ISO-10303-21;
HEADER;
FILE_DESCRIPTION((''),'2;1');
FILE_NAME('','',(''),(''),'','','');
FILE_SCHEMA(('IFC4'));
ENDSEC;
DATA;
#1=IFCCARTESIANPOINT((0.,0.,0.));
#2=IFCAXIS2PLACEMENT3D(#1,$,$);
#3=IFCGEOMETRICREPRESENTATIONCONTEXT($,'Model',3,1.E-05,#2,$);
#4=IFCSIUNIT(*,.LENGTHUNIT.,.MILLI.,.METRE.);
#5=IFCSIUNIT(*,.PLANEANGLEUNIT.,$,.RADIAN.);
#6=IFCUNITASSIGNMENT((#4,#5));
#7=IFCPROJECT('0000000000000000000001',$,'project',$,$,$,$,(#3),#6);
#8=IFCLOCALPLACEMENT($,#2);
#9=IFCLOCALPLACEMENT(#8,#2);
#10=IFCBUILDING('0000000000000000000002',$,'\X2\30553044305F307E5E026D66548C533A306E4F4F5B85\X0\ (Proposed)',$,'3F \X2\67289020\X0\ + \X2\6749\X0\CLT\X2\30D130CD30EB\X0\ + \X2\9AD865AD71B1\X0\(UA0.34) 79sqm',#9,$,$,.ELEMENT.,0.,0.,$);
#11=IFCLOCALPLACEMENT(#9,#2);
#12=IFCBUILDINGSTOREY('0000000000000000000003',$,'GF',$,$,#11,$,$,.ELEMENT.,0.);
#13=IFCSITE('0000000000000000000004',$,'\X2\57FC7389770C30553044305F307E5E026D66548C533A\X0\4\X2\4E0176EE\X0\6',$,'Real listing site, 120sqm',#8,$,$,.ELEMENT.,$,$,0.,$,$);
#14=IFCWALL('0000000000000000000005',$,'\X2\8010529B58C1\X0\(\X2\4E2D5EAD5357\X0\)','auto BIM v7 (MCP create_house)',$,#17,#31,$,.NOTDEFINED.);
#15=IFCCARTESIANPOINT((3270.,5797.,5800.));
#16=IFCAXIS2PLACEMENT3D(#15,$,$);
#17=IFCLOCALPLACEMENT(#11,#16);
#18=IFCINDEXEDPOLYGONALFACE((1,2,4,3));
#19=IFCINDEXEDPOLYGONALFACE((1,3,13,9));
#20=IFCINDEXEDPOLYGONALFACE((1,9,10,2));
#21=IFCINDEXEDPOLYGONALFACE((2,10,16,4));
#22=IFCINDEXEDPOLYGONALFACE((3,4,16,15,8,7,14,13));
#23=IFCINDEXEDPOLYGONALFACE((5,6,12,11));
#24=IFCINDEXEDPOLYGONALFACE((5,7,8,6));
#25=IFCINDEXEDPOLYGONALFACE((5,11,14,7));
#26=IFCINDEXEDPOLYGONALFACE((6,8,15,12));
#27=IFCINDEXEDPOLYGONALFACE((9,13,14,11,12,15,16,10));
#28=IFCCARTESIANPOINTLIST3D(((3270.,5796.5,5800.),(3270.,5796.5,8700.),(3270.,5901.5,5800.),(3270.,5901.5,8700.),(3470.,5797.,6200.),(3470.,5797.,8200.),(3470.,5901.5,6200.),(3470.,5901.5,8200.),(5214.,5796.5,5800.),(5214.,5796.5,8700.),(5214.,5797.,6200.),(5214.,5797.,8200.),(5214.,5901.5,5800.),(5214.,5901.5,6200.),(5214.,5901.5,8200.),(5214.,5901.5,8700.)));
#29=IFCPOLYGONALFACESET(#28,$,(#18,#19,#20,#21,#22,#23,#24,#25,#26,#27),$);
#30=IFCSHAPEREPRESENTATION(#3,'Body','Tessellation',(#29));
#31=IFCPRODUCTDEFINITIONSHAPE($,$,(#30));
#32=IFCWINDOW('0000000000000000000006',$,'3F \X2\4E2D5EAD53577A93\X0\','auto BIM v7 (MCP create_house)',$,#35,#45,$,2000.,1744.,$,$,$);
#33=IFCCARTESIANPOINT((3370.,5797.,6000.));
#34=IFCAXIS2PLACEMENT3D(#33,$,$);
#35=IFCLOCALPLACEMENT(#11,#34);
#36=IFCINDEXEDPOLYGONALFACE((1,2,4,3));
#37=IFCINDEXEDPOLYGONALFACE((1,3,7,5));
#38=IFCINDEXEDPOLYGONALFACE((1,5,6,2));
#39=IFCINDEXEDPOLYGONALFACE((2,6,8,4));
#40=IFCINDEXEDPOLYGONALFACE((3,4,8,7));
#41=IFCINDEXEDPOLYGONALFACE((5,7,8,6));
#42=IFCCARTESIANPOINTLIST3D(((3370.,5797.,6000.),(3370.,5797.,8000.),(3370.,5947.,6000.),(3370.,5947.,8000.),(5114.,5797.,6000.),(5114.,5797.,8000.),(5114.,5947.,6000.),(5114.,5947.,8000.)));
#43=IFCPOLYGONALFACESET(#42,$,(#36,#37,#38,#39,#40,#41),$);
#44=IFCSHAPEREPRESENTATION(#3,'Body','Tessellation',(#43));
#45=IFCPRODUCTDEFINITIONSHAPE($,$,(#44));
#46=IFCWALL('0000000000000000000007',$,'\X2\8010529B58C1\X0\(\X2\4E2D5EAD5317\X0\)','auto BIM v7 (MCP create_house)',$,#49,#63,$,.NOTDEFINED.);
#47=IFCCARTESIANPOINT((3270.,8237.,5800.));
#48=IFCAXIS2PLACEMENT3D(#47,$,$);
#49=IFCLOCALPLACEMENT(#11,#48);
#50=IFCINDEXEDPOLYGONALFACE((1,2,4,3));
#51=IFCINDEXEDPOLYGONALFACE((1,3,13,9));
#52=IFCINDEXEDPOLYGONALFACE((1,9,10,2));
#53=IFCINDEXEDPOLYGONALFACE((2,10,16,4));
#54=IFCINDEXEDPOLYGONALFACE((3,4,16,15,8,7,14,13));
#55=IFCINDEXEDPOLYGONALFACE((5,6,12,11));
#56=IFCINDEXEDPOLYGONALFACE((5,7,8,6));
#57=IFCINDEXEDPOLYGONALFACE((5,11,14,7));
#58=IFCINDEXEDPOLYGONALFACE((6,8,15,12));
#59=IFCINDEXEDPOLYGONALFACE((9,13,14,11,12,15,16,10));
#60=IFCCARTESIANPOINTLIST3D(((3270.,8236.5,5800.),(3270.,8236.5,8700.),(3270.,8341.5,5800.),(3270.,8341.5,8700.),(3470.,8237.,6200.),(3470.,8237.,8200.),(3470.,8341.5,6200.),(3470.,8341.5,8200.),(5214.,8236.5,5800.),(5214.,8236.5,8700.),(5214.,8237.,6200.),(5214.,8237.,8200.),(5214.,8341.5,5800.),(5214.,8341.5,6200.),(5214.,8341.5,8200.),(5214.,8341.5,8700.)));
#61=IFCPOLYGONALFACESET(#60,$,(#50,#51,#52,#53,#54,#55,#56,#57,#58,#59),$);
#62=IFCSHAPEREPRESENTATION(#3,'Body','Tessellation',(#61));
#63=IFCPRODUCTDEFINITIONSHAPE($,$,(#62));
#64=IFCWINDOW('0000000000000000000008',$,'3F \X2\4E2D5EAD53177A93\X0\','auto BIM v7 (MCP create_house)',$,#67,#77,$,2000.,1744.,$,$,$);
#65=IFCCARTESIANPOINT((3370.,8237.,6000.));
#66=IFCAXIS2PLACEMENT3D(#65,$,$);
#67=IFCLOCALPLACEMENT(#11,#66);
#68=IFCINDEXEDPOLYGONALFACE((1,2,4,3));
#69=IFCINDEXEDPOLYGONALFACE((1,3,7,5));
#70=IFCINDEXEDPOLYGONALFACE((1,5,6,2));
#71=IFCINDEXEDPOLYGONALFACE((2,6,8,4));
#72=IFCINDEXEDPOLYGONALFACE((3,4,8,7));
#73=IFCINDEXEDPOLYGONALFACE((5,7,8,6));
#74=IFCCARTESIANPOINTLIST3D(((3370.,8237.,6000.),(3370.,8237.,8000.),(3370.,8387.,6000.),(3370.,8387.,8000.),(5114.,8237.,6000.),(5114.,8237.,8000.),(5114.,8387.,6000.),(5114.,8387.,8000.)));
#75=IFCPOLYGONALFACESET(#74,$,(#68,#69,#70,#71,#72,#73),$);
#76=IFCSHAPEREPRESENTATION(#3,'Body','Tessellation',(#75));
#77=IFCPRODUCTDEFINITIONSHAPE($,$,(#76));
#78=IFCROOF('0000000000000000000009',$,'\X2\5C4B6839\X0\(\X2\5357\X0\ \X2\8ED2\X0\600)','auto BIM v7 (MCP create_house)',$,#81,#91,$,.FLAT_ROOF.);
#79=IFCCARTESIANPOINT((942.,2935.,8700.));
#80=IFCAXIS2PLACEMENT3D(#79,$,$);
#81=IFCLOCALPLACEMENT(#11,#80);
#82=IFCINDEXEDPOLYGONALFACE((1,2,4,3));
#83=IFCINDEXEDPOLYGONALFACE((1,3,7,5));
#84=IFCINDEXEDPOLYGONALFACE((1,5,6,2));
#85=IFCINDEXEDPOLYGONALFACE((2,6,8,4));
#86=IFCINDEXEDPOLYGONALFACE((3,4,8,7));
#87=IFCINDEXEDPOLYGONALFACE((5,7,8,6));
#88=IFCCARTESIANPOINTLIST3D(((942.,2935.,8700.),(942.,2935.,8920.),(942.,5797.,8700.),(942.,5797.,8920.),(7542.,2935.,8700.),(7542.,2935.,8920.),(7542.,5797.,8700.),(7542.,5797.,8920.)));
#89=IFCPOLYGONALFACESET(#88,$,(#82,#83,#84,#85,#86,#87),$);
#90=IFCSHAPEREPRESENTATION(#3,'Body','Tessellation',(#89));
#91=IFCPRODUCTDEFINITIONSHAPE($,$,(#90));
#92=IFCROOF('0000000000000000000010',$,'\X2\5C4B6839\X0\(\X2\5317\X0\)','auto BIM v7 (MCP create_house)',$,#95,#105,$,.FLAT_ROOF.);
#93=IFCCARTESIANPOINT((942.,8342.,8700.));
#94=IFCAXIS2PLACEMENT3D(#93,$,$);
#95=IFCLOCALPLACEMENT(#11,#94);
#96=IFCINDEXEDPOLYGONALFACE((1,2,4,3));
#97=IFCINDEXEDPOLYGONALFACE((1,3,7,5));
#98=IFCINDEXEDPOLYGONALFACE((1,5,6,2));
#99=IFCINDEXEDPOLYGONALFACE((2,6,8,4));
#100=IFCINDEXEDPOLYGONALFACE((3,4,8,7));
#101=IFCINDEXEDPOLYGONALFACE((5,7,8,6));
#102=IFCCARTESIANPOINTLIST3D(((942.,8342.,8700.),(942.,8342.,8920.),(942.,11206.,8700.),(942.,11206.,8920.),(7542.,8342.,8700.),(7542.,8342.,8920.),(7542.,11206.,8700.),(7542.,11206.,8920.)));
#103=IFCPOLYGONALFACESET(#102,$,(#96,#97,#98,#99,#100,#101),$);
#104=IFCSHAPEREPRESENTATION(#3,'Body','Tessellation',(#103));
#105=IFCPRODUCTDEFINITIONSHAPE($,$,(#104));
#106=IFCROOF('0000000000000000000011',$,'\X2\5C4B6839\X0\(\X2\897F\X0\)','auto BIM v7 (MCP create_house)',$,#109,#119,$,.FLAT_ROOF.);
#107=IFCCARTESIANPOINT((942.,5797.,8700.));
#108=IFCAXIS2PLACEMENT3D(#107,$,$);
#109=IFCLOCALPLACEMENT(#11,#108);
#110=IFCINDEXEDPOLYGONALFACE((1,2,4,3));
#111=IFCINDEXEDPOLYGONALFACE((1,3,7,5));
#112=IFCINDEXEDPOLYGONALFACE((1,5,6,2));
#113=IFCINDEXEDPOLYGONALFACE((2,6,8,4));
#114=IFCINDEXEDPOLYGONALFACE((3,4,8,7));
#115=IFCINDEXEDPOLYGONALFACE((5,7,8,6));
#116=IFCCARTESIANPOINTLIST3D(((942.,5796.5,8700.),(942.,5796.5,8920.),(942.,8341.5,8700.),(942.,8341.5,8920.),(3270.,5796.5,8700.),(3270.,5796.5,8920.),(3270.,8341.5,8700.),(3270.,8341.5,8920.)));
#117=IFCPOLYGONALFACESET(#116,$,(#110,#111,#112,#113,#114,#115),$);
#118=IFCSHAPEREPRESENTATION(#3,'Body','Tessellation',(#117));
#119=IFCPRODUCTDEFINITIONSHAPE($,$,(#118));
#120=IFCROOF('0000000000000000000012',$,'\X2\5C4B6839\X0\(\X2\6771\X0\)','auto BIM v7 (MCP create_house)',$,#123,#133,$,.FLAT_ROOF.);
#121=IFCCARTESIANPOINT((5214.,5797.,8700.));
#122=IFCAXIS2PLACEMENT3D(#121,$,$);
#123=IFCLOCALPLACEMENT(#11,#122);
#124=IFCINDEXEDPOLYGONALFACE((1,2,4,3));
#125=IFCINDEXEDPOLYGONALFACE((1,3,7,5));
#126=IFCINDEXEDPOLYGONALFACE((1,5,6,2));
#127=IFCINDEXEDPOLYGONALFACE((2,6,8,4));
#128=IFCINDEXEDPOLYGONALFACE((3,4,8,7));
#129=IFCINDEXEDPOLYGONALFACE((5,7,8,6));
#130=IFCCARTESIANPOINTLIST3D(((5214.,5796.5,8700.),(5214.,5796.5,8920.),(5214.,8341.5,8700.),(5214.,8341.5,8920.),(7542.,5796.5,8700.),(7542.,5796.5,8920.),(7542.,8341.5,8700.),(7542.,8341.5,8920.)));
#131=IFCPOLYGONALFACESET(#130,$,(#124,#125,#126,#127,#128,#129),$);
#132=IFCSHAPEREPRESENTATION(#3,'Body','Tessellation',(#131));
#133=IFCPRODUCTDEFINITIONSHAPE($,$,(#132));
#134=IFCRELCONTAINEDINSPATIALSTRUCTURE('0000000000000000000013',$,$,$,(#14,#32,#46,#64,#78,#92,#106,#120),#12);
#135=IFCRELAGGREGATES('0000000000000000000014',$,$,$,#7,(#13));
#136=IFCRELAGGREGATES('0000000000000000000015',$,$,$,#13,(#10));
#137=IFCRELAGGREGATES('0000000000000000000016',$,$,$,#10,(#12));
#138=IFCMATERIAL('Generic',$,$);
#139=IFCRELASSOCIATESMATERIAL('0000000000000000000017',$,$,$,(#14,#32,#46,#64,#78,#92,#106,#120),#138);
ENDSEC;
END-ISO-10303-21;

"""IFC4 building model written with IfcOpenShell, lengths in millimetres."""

from ifc_helpers import new_model, si_unit, frame, frame_2d, origin, place, context, project, spatial, rectangle, extrude, material, element, fill, save


model = new_model("IFC4")

# Units and contexts
model_context = context("Model", 3, precision=1e-05, world=origin())
ifc_project = project(units=[si_unit("LENGTHUNIT", "METRE", prefix="MILLI"), si_unit("PLANEANGLEUNIT", "RADIAN")], contexts=[model_context])

# Site, building, storey
site_placement = place(None, origin())
site = spatial("IfcSite", under=ifc_project, at=site_placement, Name="埼玉県さいたま市浦和区4丁目6", ObjectType="Real listing site, 120sqm", CompositionType="ELEMENT", RefElevation=0.0)
building_placement = place(site_placement, origin())
building = spatial("IfcBuilding", under=site, at=building_placement, Name="さいたま市浦和区の住宅 (Proposed)", ObjectType="3F 木造 + 杉CLTパネル + 高断熱(UA0.34) 79sqm", CompositionType="ELEMENT", ElevationOfRefHeight=0.0, ElevationOfTerrain=0.0)
storey_placement = place(building_placement, origin())
storey = spatial("IfcBuildingStorey", under=building, at=storey_placement, Name="GF", CompositionType="ELEMENT", Elevation=0.0)

# Shared definitions
ifc_material = material(Name="Generic")

# Walls, openings, windows
wall_1_placement = place(storey_placement, frame((3270.0, 5797.0, 5800.0)))
wall_1 = element("IfcWall", 1, at=wall_1_placement, inside=storey, material=ifc_material, Name="耐力壁(中庭南)", Description="auto BIM v7 (MCP create_house)", PredefinedType="NOTDEFINED", context=model_context, shape_type="SweptSolid", body=[
    extrude(rectangle(XDim=1944.0, YDim=105.0, at=frame_2d((972.0, 52.0))), frame((3270.0, 5797.0, 5800.0)), (0.0, 0.0, 1.0), 2900.0),
])
opening_1_placement = place(storey_placement, frame((3370.0, 5797.0, 6000.0)))
opening_1 = element("IfcOpeningElement", 2, at=opening_1_placement, cuts=wall_1, PredefinedType="NOTDEFINED", context=model_context, shape_type="SweptSolid", body=[
    extrude(rectangle(XDim=1744.0, YDim=150.0, at=frame_2d((872.0, 75.0))), frame((3370.0, 5797.0, 6000.0)), (0.0, 0.0, 1.0), 2000.0),
])
window_1_placement = place(storey_placement, frame((3370.0, 5797.0, 6000.0)))
window_1 = element("IfcWindow", 3, at=window_1_placement, inside=storey, material=ifc_material, Name="3F 中庭南窓", Description="auto BIM v7 (MCP create_house)", OverallHeight=2000.0, OverallWidth=1744.0, context=model_context, shape_type="SweptSolid", body=[
    extrude(rectangle(XDim=1744.0, YDim=150.0, at=frame_2d((872.0, 75.0))), frame((3370.0, 5797.0, 6000.0)), (0.0, 0.0, 1.0), 2000.0),
])
fill(opening_1, window_1)
wall_2_placement = place(storey_placement, frame((3270.0, 8237.0, 5800.0)))
wall_2 = element("IfcWall", 4, at=wall_2_placement, inside=storey, material=ifc_material, Name="耐力壁(中庭北)", Description="auto BIM v7 (MCP create_house)", PredefinedType="NOTDEFINED", context=model_context, shape_type="SweptSolid", body=[
    extrude(rectangle(XDim=1944.0, YDim=105.0, at=frame_2d((972.0, 52.0))), frame((3270.0, 8237.0, 5800.0)), (0.0, 0.0, 1.0), 2900.0),
])
opening_2_placement = place(storey_placement, frame((3370.0, 8237.0, 6000.0)))
opening_2 = element("IfcOpeningElement", 5, at=opening_2_placement, cuts=wall_2, PredefinedType="NOTDEFINED", context=model_context, shape_type="SweptSolid", body=[
    extrude(rectangle(XDim=1744.0, YDim=150.0, at=frame_2d((872.0, 75.0))), frame((3370.0, 8237.0, 6000.0)), (0.0, 0.0, 1.0), 2000.0),
])
window_2_placement = place(storey_placement, frame((3370.0, 8237.0, 6000.0)))
window_2 = element("IfcWindow", 6, at=window_2_placement, inside=storey, material=ifc_material, Name="3F 中庭北窓", Description="auto BIM v7 (MCP create_house)", OverallHeight=2000.0, OverallWidth=1744.0, context=model_context, shape_type="SweptSolid", body=[
    extrude(rectangle(XDim=1744.0, YDim=150.0, at=frame_2d((872.0, 75.0))), frame((3370.0, 8237.0, 6000.0)), (0.0, 0.0, 1.0), 2000.0),
])
fill(opening_2, window_2)

# Roofs
roof_1_placement = place(storey_placement, frame((942.0, 2935.0, 8700.0)))
element("IfcRoof", 7, at=roof_1_placement, inside=storey, material=ifc_material, Name="屋根(南 軒600)", Description="auto BIM v7 (MCP create_house)", PredefinedType="FLAT_ROOF", context=model_context, shape_type="SweptSolid", body=[
    extrude(rectangle(XDim=6600.0, YDim=2862.0, at=frame_2d((3300.0, 1431.0))), frame((942.0, 2935.0, 8700.0)), (0.0, 0.0, 1.0), 220.0),
])
roof_2_placement = place(storey_placement, frame((942.0, 8342.0, 8700.0)))
element("IfcRoof", 8, at=roof_2_placement, inside=storey, material=ifc_material, Name="屋根(北)", Description="auto BIM v7 (MCP create_house)", PredefinedType="FLAT_ROOF", context=model_context, shape_type="SweptSolid", body=[
    extrude(rectangle(XDim=6600.0, YDim=2864.0, at=frame_2d((3300.0, 1432.0))), frame((942.0, 8342.0, 8700.0)), (0.0, 0.0, 1.0), 220.0),
])
roof_3_placement = place(storey_placement, frame((942.0, 5797.0, 8700.0)))
element("IfcRoof", 9, at=roof_3_placement, inside=storey, material=ifc_material, Name="屋根(西)", Description="auto BIM v7 (MCP create_house)", PredefinedType="FLAT_ROOF", context=model_context, shape_type="SweptSolid", body=[
    extrude(rectangle(XDim=2328.0, YDim=2545.0, at=frame_2d((1164.0, 1272.0))), frame((942.0, 5797.0, 8700.0)), (0.0, 0.0, 1.0), 220.0),
])
roof_4_placement = place(storey_placement, frame((5214.0, 5797.0, 8700.0)))
element("IfcRoof", 10, at=roof_4_placement, inside=storey, material=ifc_material, Name="屋根(東)", Description="auto BIM v7 (MCP create_house)", PredefinedType="FLAT_ROOF", context=model_context, shape_type="SweptSolid", body=[
    extrude(rectangle(XDim=2328.0, YDim=2545.0, at=frame_2d((1164.0, 1272.0))), frame((5214.0, 5797.0, 8700.0)), (0.0, 0.0, 1.0), 220.0),
])

save(model, "model.ifc")
